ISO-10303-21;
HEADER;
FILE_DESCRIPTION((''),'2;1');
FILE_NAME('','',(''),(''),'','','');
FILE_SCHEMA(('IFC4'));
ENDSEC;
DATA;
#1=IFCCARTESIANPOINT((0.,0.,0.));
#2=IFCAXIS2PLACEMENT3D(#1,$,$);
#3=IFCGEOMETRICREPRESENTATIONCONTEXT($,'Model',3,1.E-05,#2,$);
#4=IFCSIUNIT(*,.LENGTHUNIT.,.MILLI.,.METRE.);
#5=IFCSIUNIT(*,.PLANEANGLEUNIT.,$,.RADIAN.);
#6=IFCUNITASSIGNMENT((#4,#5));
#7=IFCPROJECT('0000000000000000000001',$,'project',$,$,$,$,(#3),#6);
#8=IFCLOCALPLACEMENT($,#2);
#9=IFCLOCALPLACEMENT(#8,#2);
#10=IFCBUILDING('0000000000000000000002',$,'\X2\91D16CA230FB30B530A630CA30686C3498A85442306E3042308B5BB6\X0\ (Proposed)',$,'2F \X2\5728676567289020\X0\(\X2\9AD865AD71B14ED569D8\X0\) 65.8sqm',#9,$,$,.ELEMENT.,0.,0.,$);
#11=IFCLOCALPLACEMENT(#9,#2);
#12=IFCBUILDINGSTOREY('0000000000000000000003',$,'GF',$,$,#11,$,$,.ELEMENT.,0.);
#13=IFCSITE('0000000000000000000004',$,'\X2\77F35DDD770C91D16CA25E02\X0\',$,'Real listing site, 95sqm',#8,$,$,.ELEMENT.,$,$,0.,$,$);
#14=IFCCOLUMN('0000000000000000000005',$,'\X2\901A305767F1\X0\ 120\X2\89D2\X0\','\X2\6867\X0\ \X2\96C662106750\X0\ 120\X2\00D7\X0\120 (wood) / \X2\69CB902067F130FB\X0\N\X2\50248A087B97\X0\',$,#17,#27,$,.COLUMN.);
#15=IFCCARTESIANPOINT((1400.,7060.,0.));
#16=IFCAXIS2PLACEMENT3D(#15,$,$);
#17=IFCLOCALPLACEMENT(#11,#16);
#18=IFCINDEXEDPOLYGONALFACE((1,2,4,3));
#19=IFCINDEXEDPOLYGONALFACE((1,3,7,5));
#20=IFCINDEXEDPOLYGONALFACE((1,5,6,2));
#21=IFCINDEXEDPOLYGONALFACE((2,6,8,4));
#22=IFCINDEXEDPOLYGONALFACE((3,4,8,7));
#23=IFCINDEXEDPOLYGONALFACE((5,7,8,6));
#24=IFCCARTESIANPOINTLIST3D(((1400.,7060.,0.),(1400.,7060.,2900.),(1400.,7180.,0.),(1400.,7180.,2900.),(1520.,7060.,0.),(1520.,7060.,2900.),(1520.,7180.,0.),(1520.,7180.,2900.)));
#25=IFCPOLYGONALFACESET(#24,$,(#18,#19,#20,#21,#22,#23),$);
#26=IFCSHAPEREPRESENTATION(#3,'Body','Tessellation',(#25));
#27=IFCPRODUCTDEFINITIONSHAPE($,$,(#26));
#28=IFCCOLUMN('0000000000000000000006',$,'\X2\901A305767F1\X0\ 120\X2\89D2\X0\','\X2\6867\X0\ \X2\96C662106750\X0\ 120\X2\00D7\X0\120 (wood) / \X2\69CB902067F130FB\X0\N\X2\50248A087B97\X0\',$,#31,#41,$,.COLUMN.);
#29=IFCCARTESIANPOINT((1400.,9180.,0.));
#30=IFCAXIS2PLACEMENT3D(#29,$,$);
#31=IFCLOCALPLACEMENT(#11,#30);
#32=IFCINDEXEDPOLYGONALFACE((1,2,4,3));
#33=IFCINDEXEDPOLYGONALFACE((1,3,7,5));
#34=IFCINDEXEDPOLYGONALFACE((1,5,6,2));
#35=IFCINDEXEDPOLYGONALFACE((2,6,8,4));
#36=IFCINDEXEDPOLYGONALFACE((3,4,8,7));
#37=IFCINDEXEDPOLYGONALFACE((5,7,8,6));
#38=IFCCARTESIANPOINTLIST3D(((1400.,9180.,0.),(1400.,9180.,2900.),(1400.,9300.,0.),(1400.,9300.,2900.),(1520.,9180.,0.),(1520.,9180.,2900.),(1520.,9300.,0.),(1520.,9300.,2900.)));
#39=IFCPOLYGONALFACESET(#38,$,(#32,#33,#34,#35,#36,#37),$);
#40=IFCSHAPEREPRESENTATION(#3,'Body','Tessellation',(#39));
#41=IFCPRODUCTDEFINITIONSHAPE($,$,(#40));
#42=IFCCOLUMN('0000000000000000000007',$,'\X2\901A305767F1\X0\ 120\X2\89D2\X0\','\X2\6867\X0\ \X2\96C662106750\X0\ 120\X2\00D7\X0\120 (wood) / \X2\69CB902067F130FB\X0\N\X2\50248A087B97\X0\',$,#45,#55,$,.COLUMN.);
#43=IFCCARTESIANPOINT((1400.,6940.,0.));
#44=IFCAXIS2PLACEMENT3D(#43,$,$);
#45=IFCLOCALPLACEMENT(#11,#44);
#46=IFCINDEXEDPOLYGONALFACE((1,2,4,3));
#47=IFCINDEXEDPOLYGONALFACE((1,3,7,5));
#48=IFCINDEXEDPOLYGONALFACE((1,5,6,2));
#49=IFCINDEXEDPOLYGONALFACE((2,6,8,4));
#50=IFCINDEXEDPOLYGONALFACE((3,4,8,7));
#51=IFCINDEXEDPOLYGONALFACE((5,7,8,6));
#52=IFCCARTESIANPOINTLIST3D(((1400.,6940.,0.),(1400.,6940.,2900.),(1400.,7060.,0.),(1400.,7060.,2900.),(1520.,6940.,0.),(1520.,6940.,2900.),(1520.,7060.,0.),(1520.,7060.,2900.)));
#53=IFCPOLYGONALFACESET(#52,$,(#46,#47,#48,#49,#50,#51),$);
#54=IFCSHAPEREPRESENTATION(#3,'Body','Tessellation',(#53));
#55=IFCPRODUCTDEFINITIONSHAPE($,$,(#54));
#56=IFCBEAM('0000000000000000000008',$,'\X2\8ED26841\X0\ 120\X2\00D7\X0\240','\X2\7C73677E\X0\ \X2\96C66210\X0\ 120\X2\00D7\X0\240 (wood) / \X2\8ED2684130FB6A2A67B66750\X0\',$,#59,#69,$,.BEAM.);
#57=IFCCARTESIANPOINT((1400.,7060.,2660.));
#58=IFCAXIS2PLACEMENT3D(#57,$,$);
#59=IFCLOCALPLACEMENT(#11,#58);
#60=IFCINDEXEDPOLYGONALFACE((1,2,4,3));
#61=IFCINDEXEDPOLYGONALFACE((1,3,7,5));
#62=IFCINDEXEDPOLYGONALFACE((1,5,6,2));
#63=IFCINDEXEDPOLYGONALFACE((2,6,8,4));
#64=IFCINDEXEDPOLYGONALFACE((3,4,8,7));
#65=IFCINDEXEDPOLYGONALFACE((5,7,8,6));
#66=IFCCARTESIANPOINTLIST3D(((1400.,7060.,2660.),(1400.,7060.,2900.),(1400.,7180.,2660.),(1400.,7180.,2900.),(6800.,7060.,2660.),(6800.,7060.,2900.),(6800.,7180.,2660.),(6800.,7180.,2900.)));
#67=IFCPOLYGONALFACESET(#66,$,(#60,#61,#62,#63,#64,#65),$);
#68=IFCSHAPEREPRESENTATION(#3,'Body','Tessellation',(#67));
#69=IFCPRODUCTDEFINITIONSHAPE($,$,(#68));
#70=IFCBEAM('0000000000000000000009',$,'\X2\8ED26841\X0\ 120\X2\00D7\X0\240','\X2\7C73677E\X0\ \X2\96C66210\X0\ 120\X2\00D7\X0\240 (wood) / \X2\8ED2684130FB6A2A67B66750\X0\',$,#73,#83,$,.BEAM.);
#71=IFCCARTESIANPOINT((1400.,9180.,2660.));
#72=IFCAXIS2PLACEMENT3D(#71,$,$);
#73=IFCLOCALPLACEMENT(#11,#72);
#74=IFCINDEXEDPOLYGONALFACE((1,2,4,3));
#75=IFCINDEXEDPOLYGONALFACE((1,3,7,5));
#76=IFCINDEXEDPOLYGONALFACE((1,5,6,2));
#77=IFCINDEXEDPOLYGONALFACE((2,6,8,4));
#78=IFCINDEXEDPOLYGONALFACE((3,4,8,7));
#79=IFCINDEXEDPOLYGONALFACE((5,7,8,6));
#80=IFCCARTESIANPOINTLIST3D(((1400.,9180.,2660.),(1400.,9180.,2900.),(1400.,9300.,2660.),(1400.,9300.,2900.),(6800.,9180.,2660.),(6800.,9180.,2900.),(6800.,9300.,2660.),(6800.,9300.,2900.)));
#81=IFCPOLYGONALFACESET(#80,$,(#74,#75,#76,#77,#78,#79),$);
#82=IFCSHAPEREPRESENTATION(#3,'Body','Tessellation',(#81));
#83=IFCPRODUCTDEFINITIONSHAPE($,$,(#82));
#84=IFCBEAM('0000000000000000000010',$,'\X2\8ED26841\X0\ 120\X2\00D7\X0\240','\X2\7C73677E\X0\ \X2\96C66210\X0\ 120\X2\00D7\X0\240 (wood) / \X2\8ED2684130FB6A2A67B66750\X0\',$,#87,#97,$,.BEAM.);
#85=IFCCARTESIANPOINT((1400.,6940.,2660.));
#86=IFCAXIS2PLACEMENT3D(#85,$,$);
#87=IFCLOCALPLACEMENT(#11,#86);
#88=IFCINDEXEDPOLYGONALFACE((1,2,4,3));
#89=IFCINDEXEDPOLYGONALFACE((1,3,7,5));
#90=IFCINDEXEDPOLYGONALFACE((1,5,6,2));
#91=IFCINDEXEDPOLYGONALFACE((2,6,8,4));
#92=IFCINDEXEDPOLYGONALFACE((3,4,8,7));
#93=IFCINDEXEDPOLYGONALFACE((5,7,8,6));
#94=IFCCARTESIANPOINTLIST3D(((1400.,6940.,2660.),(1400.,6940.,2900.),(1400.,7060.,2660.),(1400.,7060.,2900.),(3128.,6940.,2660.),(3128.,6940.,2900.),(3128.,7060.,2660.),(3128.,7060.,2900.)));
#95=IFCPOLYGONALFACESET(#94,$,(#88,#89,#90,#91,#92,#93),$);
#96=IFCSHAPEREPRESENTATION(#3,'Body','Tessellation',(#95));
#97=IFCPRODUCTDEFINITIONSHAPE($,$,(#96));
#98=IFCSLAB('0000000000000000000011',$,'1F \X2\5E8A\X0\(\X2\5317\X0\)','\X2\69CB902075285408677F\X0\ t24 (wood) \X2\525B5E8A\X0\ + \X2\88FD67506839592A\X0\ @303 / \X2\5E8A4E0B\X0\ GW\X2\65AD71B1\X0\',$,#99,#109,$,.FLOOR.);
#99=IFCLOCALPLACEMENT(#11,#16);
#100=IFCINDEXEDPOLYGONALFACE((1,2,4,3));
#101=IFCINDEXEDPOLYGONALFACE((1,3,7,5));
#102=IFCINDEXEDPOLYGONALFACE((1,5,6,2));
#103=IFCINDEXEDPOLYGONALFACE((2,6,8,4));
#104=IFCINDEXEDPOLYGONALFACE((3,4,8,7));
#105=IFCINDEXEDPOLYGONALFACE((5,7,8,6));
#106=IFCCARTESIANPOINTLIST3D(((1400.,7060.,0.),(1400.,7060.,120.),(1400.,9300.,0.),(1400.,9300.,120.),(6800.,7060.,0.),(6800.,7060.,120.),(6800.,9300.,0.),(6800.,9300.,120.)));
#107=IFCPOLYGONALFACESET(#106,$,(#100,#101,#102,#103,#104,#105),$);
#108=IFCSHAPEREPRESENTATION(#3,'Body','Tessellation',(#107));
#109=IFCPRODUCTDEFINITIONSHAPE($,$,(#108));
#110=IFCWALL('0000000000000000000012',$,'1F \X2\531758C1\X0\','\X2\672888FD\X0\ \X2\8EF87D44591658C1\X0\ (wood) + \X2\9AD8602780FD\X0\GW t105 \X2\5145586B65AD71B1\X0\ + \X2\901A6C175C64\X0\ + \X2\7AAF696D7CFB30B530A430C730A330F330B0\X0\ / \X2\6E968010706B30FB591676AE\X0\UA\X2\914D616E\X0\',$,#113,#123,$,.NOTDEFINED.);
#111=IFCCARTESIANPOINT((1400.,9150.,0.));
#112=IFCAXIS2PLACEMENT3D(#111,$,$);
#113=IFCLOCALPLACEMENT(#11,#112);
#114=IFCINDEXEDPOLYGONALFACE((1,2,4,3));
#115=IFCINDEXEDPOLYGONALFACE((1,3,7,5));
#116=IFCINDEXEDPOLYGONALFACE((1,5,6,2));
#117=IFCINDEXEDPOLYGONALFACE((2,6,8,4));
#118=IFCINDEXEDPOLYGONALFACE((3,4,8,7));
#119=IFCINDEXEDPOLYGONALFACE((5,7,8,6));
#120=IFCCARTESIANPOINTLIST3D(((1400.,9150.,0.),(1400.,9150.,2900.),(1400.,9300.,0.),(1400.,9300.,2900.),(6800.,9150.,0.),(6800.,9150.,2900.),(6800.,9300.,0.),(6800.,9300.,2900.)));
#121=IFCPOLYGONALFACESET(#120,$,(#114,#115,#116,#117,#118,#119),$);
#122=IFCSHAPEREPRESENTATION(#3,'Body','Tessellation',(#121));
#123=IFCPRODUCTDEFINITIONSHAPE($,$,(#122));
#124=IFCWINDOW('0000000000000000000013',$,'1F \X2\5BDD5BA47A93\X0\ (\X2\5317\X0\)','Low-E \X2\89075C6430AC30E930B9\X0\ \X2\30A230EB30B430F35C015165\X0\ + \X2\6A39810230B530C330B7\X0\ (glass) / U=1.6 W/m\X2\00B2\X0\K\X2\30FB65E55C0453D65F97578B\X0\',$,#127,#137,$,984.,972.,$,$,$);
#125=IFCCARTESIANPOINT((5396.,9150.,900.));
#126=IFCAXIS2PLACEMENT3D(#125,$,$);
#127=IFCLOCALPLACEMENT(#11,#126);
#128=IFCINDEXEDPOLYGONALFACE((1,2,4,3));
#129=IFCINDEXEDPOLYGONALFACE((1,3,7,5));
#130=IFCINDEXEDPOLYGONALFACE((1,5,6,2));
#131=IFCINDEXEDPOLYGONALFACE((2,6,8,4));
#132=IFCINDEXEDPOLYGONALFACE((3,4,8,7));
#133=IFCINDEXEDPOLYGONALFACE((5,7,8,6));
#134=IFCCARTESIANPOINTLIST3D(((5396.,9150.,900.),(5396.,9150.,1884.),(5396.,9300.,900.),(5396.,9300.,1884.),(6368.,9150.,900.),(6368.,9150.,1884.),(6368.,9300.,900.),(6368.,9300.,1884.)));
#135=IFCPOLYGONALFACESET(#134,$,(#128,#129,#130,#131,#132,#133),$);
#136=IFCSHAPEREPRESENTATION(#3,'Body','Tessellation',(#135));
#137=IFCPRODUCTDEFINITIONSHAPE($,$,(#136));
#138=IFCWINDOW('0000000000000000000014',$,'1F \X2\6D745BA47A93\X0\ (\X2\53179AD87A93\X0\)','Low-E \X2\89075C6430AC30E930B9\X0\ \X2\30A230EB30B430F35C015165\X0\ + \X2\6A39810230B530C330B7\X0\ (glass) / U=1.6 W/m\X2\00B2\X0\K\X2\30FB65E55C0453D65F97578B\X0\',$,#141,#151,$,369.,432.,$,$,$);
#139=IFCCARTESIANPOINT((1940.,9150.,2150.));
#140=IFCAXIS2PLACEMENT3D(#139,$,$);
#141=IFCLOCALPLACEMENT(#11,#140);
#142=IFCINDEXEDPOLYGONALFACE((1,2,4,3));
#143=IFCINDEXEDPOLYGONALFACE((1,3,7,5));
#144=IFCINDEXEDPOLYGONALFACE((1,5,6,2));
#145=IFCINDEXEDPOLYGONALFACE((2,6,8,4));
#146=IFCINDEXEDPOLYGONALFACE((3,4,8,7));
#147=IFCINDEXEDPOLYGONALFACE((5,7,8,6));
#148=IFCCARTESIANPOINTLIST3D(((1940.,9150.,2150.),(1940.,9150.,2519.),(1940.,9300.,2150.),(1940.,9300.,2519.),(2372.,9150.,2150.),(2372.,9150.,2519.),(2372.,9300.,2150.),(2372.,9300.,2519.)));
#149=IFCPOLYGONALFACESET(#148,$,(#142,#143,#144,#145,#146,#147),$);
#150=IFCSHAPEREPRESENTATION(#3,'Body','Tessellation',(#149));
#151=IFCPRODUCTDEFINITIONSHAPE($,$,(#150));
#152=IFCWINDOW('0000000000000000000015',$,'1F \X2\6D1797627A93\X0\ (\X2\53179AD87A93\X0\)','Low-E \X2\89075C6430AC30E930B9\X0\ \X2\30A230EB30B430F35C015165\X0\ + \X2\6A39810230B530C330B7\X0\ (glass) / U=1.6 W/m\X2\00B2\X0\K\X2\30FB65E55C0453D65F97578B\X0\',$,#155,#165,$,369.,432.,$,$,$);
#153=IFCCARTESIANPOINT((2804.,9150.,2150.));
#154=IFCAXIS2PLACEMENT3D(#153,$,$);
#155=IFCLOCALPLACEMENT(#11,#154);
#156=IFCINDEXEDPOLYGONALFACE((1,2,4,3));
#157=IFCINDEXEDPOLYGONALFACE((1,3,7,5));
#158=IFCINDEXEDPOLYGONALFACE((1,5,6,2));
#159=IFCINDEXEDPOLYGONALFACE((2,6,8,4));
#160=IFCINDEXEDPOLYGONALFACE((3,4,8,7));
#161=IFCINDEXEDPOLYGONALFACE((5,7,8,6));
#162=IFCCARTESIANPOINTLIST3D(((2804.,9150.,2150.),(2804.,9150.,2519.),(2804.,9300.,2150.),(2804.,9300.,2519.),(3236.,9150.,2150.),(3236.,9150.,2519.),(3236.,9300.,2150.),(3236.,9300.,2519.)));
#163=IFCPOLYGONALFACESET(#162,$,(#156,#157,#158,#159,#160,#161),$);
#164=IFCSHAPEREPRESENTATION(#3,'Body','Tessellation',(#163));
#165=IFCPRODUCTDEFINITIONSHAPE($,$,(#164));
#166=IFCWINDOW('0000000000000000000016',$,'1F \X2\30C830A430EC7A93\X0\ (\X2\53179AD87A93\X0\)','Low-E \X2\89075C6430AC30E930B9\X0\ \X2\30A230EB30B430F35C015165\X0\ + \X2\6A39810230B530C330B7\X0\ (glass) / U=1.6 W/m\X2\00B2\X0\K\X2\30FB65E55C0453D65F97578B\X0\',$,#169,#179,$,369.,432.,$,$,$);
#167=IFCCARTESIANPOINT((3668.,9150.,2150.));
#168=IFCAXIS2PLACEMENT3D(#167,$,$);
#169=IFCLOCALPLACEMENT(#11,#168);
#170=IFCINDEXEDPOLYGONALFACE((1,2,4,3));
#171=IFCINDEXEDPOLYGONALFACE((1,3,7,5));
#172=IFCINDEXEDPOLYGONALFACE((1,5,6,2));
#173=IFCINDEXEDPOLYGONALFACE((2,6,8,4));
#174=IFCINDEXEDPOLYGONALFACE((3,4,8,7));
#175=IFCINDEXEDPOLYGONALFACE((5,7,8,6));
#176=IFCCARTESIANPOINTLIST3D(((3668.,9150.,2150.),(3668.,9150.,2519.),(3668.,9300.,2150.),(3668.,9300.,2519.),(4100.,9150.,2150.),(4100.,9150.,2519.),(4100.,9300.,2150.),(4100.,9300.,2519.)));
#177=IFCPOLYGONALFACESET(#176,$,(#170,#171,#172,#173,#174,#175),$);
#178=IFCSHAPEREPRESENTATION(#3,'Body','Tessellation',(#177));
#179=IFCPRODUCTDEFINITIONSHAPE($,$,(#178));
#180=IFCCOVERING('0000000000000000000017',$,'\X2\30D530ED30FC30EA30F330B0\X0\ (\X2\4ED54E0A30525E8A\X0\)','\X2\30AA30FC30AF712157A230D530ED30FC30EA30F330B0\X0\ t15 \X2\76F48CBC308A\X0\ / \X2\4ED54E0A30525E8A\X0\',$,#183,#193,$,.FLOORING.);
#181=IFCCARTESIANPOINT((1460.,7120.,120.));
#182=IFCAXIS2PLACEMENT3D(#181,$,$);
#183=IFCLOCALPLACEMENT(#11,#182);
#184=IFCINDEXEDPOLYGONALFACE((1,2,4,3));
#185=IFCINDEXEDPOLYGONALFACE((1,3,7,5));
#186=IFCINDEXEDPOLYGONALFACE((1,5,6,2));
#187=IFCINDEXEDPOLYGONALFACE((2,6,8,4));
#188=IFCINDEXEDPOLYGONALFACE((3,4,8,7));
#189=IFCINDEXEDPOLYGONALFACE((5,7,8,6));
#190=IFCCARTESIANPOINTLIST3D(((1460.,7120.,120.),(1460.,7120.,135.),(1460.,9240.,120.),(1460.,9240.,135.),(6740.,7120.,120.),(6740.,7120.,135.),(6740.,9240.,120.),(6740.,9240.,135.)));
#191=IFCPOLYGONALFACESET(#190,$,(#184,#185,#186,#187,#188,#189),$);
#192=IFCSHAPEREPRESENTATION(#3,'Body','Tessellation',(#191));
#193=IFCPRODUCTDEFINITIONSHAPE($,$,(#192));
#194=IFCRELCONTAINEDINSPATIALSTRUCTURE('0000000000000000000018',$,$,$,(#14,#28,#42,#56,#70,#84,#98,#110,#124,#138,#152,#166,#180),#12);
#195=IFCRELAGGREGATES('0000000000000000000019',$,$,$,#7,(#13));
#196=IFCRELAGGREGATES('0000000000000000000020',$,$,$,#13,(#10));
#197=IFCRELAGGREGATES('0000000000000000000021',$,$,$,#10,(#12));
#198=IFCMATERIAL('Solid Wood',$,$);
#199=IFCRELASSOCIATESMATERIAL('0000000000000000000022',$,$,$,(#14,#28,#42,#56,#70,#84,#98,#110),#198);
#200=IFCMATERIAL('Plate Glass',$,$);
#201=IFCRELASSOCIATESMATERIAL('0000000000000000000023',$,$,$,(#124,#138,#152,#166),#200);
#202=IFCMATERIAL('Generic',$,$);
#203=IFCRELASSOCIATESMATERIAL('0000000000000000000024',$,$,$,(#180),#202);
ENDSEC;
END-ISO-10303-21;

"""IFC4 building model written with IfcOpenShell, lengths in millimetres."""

from ifc_helpers import new_model, si_unit, frame, frame_2d, origin, place, context, project, spatial, rectangle, extrude, material, element, fill, save


model = new_model("IFC4")

# Units and contexts
model_context = context("Model", 3, precision=1e-05, world=origin())
ifc_project = project(units=[si_unit("LENGTHUNIT", "METRE", prefix="MILLI"), si_unit("PLANEANGLEUNIT", "RADIAN")], contexts=[model_context])

# Site, building, storey
site_placement = place(None, origin())
site = spatial("IfcSite", under=ifc_project, at=site_placement, Name="石川県金沢市", ObjectType="Real listing site, 95sqm", CompositionType="ELEMENT", RefElevation=0.0)
building_placement = place(site_placement, origin())
building = spatial("IfcBuilding", under=site, at=building_placement, Name="金沢・サウナと水風呂のある家 (Proposed)", ObjectType="2F 在来木造(高断熱仕様) 65.8sqm", CompositionType="ELEMENT", ElevationOfRefHeight=0.0, ElevationOfTerrain=0.0)
storey_placement = place(building_placement, origin())
storey = spatial("IfcBuildingStorey", under=building, at=storey_placement, Name="GF", CompositionType="ELEMENT", Elevation=0.0)

# Columns
ifc_material_1 = material(Name="Solid Wood")
column_1_placement = place(storey_placement, frame((1400.0, 7060.0, 0.0)))
element("IfcColumn", 1, at=column_1_placement, inside=storey, material=ifc_material_1, Name="通し柱 120角", Description="桧 集成材 120×120 (wood) / 構造柱・N値計算", PredefinedType="COLUMN", context=model_context, shape_type="SweptSolid", body=[
    extrude(rectangle(XDim=120.0, YDim=120.0, at=frame_2d((60.0, 60.0))), frame((1400.0, 7060.0, 0.0)), (0.0, 0.0, 1.0), 2900.0),
])
column_2_placement = place(storey_placement, frame((1400.0, 9180.0, 0.0)))
element("IfcColumn", 2, at=column_2_placement, inside=storey, material=ifc_material_1, Name="通し柱 120角", Description="桧 集成材 120×120 (wood) / 構造柱・N値計算", PredefinedType="COLUMN", context=model_context, shape_type="SweptSolid", body=[
    extrude(rectangle(XDim=120.0, YDim=120.0, at=frame_2d((60.0, 60.0))), frame((1400.0, 9180.0, 0.0)), (0.0, 0.0, 1.0), 2900.0),
])
column_3_placement = place(storey_placement, frame((1400.0, 6940.0, 0.0)))
element("IfcColumn", 3, at=column_3_placement, inside=storey, material=ifc_material_1, Name="通し柱 120角", Description="桧 集成材 120×120 (wood) / 構造柱・N値計算", PredefinedType="COLUMN", context=model_context, shape_type="SweptSolid", body=[
    extrude(rectangle(XDim=120.0, YDim=120.0, at=frame_2d((60.0, 60.0))), frame((1400.0, 6940.0, 0.0)), (0.0, 0.0, 1.0), 2900.0),
])

# Beams
beam_1_placement = place(storey_placement, frame((1400.0, 7060.0, 2660.0)))
element("IfcBeam", 4, at=beam_1_placement, inside=storey, material=ifc_material_1, Name="軒桁 120×240", Description="米松 集成 120×240 (wood) / 軒桁・横架材", PredefinedType="BEAM", context=model_context, shape_type="SweptSolid", body=[
    extrude(rectangle(XDim=5400.0, YDim=120.0, at=frame_2d((2700.0, 60.0))), frame((1400.0, 7060.0, 2660.0)), (0.0, 0.0, 1.0), 240.0),
])
beam_2_placement = place(storey_placement, frame((1400.0, 9180.0, 2660.0)))
element("IfcBeam", 5, at=beam_2_placement, inside=storey, material=ifc_material_1, Name="軒桁 120×240", Description="米松 集成 120×240 (wood) / 軒桁・横架材", PredefinedType="BEAM", context=model_context, shape_type="SweptSolid", body=[
    extrude(rectangle(XDim=5400.0, YDim=120.0, at=frame_2d((2700.0, 60.0))), frame((1400.0, 9180.0, 2660.0)), (0.0, 0.0, 1.0), 240.0),
])
beam_3_placement = place(storey_placement, frame((1400.0, 6940.0, 2660.0)))
element("IfcBeam", 6, at=beam_3_placement, inside=storey, material=ifc_material_1, Name="軒桁 120×240", Description="米松 集成 120×240 (wood) / 軒桁・横架材", PredefinedType="BEAM", context=model_context, shape_type="SweptSolid", body=[
    extrude(rectangle(XDim=1728.0, YDim=120.0, at=frame_2d((864.0, 60.0))), frame((1400.0, 6940.0, 2660.0)), (0.0, 0.0, 1.0), 240.0),
])

# Slab
slab_placement = place(storey_placement, frame((1400.0, 7060.0, 0.0)))
element("IfcSlab", 7, at=slab_placement, inside=storey, material=ifc_material_1, Name="1F 床(北)", Description="構造用合板 t24 (wood) 剛床 + 製材根太 @303 / 床下 GW断熱", PredefinedType="FLOOR", context=model_context, shape_type="SweptSolid", body=[
    extrude(rectangle(XDim=5400.0, YDim=2240.0, at=frame_2d((2700.0, 1120.0))), frame((1400.0, 7060.0, 0.0)), (0.0, 0.0, 1.0), 120.0),
])

# Wall, openings, windows
wall_1_placement = place(storey_placement, frame((1400.0, 9150.0, 0.0)))
wall_1 = element("IfcWall", 8, at=wall_1_placement, inside=storey, material=ifc_material_1, Name="1F 北壁", Description="木製 軸組外壁 (wood) + 高性能GW t105 充填断熱 + 通気層 + 窯業系サイディング / 準耐火・外皮UA配慮", PredefinedType="NOTDEFINED", context=model_context, shape_type="SweptSolid", body=[
    extrude(rectangle(XDim=5400.0, YDim=150.0, at=frame_2d((2700.0, 75.0))), frame((1400.0, 9150.0, 0.0)), (0.0, 0.0, 1.0), 2900.0),
])
opening_1_placement = place(storey_placement, frame((5396.0, 9150.0, 900.0)))
opening_1 = element("IfcOpeningElement", 9, at=opening_1_placement, cuts=wall_1, PredefinedType="NOTDEFINED", context=model_context, shape_type="SweptSolid", body=[
    extrude(rectangle(XDim=972.0, YDim=150.0, at=frame_2d((486.0, 75.0))), frame((5396.0, 9150.0, 900.0)), (0.0, 0.0, 1.0), 984.0),
])
opening_2_placement = place(storey_placement, frame((1940.0, 9150.0, 2150.0)))
opening_2 = element("IfcOpeningElement", 10, at=opening_2_placement, cuts=wall_1, PredefinedType="NOTDEFINED", context=model_context, shape_type="SweptSolid", body=[
    extrude(rectangle(XDim=432.0, YDim=150.0, at=frame_2d((216.0, 75.0))), frame((1940.0, 9150.0, 2150.0)), (0.0, 0.0, 1.0), 369.0),
])
opening_3_placement = place(storey_placement, frame((2804.0, 9150.0, 2150.0)))
opening_3 = element("IfcOpeningElement", 11, at=opening_3_placement, cuts=wall_1, PredefinedType="NOTDEFINED", context=model_context, shape_type="SweptSolid", body=[
    extrude(rectangle(XDim=432.0, YDim=150.0, at=frame_2d((216.0, 75.0))), frame((2804.0, 9150.0, 2150.0)), (0.0, 0.0, 1.0), 369.0),
])
opening_4_placement = place(storey_placement, frame((3668.0, 9150.0, 2150.0)))
opening_4 = element("IfcOpeningElement", 12, at=opening_4_placement, cuts=wall_1, PredefinedType="NOTDEFINED", context=model_context, shape_type="SweptSolid", body=[
    extrude(rectangle(XDim=432.0, YDim=150.0, at=frame_2d((216.0, 75.0))), frame((3668.0, 9150.0, 2150.0)), (0.0, 0.0, 1.0), 369.0),
])
ifc_material_2 = material(Name="Plate Glass")
window_1_placement = place(storey_placement, frame((5396.0, 9150.0, 900.0)))
window_1 = element("IfcWindow", 13, at=window_1_placement, inside=storey, material=ifc_material_2, Name="1F 寝室窓 (北)", Description="Low-E 複層ガラス アルゴン封入 + 樹脂サッシ (glass) / U=1.6 W/m²K・日射取得型", OverallHeight=984.0, OverallWidth=972.0, context=model_context, shape_type="SweptSolid", body=[
    extrude(rectangle(XDim=972.0, YDim=150.0, at=frame_2d((486.0, 75.0))), frame((5396.0, 9150.0, 900.0)), (0.0, 0.0, 1.0), 984.0),
])
fill(opening_1, window_1)
window_2_placement = place(storey_placement, frame((1940.0, 9150.0, 2150.0)))
window_2 = element("IfcWindow", 14, at=window_2_placement, inside=storey, material=ifc_material_2, Name="1F 浴室窓 (北高窓)", Description="Low-E 複層ガラス アルゴン封入 + 樹脂サッシ (glass) / U=1.6 W/m²K・日射取得型", OverallHeight=369.0, OverallWidth=432.0, context=model_context, shape_type="SweptSolid", body=[
    extrude(rectangle(XDim=432.0, YDim=150.0, at=frame_2d((216.0, 75.0))), frame((1940.0, 9150.0, 2150.0)), (0.0, 0.0, 1.0), 369.0),
])
fill(opening_2, window_2)
window_3_placement = place(storey_placement, frame((2804.0, 9150.0, 2150.0)))
window_3 = element("IfcWindow", 15, at=window_3_placement, inside=storey, material=ifc_material_2, Name="1F 洗面窓 (北高窓)", Description="Low-E 複層ガラス アルゴン封入 + 樹脂サッシ (glass) / U=1.6 W/m²K・日射取得型", OverallHeight=369.0, OverallWidth=432.0, context=model_context, shape_type="SweptSolid", body=[
    extrude(rectangle(XDim=432.0, YDim=150.0, at=frame_2d((216.0, 75.0))), frame((2804.0, 9150.0, 2150.0)), (0.0, 0.0, 1.0), 369.0),
])
fill(opening_3, window_3)
window_4_placement = place(storey_placement, frame((3668.0, 9150.0, 2150.0)))
window_4 = element("IfcWindow", 16, at=window_4_placement, inside=storey, material=ifc_material_2, Name="1F トイレ窓 (北高窓)", Description="Low-E 複層ガラス アルゴン封入 + 樹脂サッシ (glass) / U=1.6 W/m²K・日射取得型", OverallHeight=369.0, OverallWidth=432.0, context=model_context, shape_type="SweptSolid", body=[
    extrude(rectangle(XDim=432.0, YDim=150.0, at=frame_2d((216.0, 75.0))), frame((3668.0, 9150.0, 2150.0)), (0.0, 0.0, 1.0), 369.0),
])
fill(opening_4, window_4)

# Covering
ifc_material_3 = material(Name="Generic")
covering_1_placement = place(storey_placement, frame((1460.0, 7120.0, 120.0)))
element("IfcCovering", 17, at=covering_1_placement, inside=storey, material=ifc_material_3, Name="フローリング (仕上げ床)", Description="オーク無垢フローリング t15 直貼り / 仕上げ床", PredefinedType="FLOORING", context=model_context, shape_type="SweptSolid", body=[
    extrude(rectangle(XDim=5280.0, YDim=2120.0, at=frame_2d((2640.0, 1060.0))), frame((1460.0, 7120.0, 120.0)), (0.0, 0.0, 1.0), 15.0),
])

save(model, "model.ifc")
